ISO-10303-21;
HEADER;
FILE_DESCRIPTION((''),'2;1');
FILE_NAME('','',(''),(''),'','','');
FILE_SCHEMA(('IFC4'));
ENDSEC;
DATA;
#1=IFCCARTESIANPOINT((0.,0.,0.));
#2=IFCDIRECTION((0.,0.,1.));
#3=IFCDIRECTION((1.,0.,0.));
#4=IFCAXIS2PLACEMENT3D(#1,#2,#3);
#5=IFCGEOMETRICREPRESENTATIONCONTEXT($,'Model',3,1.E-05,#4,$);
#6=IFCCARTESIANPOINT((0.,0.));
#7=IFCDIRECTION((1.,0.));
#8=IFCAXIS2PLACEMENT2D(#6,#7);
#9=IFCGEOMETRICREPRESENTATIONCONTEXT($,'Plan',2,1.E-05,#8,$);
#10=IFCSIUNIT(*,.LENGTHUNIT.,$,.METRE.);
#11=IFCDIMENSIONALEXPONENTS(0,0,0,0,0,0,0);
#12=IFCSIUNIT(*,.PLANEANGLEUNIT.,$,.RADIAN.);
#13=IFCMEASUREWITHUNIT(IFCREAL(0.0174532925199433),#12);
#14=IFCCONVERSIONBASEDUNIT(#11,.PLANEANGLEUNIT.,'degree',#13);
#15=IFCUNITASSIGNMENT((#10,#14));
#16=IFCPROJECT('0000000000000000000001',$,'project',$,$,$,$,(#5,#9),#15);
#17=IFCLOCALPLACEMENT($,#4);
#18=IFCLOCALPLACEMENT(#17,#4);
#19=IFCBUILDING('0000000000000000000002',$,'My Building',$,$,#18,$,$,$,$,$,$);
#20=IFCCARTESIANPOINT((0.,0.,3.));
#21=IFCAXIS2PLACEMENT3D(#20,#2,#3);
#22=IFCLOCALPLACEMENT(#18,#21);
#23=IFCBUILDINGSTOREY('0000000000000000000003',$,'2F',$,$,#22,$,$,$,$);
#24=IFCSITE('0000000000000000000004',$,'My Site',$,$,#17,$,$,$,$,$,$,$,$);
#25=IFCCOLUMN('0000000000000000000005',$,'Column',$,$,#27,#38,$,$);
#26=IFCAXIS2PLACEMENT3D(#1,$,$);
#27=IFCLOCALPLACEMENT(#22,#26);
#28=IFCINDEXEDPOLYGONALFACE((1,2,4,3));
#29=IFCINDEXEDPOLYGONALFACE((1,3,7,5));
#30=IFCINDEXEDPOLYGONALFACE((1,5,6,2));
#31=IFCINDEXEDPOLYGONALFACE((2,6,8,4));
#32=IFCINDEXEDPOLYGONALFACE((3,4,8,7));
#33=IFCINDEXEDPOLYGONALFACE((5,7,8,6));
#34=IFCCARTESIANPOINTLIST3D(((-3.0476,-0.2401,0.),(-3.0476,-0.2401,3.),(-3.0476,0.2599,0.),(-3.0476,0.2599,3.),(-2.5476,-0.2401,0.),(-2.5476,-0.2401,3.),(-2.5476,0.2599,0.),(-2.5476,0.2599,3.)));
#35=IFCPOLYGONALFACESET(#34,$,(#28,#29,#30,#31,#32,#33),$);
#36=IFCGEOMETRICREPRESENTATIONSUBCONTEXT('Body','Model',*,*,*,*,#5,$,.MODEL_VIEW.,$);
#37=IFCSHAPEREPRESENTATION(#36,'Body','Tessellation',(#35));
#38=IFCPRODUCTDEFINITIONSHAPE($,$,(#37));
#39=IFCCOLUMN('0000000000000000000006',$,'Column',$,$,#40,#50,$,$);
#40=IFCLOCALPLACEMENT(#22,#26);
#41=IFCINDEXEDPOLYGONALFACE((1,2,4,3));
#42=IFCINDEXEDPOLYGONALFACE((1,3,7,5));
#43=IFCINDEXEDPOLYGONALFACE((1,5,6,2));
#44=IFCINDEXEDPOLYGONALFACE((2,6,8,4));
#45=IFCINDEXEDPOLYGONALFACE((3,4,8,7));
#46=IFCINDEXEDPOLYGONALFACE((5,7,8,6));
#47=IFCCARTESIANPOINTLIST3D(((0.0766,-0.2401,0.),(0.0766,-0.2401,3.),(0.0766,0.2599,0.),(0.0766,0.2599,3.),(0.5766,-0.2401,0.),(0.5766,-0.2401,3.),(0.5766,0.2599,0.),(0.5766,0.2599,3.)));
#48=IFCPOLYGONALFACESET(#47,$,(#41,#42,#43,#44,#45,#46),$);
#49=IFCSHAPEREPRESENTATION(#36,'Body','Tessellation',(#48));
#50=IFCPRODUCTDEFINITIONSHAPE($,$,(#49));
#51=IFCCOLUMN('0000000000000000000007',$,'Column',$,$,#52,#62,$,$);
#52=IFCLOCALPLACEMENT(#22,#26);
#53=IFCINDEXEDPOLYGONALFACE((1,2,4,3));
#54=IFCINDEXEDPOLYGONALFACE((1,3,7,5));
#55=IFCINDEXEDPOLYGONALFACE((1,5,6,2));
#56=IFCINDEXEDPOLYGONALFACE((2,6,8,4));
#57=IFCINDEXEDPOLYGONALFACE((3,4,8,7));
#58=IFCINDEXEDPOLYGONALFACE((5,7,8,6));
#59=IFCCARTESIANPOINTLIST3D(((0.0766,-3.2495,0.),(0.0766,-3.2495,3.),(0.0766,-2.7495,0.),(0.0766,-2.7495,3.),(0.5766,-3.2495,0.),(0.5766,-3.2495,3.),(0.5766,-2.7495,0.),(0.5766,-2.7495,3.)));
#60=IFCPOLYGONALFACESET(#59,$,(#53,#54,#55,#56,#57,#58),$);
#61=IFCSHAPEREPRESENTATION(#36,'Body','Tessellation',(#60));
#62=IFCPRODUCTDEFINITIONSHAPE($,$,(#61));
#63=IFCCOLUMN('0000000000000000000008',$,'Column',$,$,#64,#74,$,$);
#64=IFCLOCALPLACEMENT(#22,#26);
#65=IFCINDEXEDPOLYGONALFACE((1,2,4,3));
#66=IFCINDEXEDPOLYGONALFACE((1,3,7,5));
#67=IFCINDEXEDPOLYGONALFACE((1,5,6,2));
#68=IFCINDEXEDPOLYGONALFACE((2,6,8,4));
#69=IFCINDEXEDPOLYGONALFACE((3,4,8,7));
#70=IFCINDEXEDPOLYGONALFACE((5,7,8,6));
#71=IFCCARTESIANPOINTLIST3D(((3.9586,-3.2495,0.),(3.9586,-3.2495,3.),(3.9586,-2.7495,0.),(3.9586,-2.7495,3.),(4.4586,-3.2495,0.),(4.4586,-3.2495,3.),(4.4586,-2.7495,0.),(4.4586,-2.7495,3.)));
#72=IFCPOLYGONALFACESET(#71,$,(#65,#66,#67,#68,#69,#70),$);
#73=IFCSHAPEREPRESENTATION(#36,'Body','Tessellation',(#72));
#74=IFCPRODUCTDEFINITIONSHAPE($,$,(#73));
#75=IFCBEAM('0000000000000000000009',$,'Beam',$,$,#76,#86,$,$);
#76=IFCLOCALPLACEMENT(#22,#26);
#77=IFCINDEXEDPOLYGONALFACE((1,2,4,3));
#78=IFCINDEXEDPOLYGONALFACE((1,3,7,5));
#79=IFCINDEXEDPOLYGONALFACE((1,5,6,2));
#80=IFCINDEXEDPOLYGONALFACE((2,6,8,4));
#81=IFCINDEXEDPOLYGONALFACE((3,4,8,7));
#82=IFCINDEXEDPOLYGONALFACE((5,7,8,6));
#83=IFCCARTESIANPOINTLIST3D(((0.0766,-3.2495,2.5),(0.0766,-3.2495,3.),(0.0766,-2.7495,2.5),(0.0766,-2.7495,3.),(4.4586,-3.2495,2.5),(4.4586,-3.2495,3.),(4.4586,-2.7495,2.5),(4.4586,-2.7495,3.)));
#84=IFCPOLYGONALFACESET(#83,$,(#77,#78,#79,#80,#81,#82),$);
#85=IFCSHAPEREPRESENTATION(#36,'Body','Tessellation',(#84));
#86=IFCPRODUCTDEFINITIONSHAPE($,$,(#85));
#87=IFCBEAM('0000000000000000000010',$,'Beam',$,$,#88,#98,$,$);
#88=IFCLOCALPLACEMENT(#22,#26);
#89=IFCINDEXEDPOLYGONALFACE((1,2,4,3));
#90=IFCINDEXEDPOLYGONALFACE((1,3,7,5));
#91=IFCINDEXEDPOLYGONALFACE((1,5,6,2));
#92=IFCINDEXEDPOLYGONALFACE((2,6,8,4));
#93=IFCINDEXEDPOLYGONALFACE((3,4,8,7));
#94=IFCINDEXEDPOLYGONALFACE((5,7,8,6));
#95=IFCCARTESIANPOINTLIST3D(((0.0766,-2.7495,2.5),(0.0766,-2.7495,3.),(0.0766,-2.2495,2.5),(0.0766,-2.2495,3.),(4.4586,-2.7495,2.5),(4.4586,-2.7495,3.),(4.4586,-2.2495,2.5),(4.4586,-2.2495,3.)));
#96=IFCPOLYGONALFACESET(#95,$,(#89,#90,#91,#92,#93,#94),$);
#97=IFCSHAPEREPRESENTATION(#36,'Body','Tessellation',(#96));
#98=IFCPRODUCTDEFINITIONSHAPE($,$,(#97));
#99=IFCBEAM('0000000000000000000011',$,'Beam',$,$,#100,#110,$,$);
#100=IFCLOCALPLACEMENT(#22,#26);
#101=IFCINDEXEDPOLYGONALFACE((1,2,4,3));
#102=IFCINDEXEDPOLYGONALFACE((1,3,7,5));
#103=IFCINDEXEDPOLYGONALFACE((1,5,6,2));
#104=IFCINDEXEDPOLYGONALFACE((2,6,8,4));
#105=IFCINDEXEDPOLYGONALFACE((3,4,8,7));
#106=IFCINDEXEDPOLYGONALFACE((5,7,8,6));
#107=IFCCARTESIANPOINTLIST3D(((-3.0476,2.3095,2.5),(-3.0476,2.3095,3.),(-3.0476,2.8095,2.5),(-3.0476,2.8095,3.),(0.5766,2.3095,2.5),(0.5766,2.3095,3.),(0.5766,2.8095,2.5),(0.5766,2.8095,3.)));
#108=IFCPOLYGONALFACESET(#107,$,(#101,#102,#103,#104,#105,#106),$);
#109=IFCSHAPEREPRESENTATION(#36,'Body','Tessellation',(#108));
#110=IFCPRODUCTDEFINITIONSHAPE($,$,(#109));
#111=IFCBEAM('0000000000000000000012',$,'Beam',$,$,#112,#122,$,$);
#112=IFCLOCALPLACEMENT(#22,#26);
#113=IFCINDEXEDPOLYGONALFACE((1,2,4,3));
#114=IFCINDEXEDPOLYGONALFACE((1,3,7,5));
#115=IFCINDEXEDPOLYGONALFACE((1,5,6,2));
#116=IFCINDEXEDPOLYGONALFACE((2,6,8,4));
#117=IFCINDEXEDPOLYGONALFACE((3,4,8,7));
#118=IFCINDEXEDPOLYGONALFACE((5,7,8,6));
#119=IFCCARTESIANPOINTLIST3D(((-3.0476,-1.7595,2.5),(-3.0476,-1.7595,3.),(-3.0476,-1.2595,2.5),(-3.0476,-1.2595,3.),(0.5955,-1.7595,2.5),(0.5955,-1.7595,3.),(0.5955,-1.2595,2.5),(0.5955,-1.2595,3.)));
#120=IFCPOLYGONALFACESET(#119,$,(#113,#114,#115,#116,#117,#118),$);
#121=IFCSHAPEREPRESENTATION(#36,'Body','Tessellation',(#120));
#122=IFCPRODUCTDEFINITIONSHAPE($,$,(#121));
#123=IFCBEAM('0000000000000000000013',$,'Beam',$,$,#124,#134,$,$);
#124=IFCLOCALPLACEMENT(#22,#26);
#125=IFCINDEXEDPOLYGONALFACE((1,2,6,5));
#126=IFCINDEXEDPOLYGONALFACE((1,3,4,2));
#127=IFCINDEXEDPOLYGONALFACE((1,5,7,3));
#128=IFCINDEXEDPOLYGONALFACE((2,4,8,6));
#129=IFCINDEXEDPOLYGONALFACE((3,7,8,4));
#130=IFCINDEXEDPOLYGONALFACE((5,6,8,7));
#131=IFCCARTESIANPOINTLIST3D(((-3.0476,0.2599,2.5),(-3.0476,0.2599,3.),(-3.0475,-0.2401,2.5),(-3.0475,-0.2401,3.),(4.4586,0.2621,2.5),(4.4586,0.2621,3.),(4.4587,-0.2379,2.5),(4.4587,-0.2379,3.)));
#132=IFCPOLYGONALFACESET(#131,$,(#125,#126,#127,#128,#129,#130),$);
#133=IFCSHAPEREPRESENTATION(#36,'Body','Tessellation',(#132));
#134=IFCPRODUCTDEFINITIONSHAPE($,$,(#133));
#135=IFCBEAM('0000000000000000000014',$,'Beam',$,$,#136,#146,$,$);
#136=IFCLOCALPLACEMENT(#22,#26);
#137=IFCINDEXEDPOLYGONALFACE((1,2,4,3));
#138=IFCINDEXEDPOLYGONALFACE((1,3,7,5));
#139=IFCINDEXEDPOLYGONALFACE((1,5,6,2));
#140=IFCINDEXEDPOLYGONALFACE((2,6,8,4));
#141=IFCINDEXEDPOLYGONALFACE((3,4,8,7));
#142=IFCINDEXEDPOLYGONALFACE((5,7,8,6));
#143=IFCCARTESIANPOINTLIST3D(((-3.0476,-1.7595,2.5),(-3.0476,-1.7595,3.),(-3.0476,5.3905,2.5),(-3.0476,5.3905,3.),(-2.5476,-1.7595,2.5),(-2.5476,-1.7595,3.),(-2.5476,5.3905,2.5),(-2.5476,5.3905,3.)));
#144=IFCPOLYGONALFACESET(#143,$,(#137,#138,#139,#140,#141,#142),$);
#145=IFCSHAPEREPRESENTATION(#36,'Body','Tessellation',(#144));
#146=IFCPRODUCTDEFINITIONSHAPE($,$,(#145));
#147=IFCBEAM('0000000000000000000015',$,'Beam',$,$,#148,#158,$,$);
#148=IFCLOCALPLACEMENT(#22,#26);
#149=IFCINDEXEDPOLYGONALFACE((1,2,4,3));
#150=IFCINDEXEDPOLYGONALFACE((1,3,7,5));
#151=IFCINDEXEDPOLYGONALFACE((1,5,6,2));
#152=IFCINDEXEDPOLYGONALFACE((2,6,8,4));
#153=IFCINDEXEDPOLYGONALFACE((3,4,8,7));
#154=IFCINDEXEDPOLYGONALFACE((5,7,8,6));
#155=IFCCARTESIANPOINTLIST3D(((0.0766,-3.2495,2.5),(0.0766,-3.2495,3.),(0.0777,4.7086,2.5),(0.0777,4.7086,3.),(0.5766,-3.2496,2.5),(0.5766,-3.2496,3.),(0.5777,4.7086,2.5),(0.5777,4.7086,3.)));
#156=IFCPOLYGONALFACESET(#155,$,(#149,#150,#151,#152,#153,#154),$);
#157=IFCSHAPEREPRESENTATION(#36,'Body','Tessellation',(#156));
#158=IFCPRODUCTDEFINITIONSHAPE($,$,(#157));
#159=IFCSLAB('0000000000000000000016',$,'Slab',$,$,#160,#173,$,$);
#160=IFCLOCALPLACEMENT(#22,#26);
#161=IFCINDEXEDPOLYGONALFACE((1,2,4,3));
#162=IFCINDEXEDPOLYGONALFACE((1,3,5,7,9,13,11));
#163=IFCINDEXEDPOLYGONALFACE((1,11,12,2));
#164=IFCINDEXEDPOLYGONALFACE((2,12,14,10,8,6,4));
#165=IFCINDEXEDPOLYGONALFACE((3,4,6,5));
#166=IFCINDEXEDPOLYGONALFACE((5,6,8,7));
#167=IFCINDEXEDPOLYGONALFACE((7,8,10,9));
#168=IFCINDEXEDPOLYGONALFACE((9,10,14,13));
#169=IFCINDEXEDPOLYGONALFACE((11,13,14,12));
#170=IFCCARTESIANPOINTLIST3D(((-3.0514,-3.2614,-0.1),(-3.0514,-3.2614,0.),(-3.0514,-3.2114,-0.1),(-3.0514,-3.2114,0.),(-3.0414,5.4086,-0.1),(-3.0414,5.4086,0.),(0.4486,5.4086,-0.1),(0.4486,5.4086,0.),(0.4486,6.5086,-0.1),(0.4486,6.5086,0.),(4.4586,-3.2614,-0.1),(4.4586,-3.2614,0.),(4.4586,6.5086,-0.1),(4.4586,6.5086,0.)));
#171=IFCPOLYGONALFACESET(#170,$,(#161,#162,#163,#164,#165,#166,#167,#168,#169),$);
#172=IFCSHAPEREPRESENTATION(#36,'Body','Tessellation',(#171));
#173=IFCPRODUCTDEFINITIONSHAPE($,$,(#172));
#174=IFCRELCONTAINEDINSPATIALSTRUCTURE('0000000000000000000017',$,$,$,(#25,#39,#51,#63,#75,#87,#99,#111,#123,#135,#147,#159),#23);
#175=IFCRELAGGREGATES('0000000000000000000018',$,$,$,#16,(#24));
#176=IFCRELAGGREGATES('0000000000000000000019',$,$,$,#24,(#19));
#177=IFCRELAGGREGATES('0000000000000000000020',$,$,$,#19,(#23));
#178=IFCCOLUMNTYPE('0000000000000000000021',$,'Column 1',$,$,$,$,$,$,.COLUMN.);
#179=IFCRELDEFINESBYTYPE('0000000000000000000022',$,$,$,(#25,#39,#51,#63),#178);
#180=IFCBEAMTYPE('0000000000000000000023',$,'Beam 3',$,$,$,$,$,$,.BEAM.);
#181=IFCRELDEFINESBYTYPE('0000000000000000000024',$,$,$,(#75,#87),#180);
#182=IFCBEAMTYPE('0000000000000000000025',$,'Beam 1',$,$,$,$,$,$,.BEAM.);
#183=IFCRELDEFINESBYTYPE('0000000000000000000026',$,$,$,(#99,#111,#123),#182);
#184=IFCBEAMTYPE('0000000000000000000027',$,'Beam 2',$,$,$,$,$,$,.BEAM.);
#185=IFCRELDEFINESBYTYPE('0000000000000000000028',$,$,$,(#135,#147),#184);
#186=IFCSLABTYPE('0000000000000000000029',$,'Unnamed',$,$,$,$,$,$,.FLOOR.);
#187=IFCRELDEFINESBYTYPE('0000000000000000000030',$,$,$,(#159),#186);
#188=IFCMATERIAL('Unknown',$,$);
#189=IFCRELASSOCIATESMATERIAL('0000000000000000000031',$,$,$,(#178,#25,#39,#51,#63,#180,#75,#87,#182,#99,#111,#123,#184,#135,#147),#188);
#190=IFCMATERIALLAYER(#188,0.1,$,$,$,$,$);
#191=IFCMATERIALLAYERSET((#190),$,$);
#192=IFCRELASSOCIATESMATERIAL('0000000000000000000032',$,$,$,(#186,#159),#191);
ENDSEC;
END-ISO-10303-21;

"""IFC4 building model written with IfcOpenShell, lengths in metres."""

from ifc_helpers import new_model, entity, si_unit, converted_unit, frame, origin_with_axes, origin_2d_with_axis, place, context, subcontext, project, spatial, indexed_curve, outline, extrude, material, layer, layer_set, layer_usage, material_profile, profile_set, profile_usage, type_object, element, save


model = new_model("IFC4")

# Units and contexts
model_context = context("Model", 3, precision=1e-05, world=origin_with_axes())
plan_context = context("Plan", 2, precision=1e-05, world=origin_2d_with_axis())
body_context_1 = subcontext(model_context, "Body", "Model", "MODEL_VIEW")
ifc_project = project(units=[si_unit("LENGTHUNIT", "METRE"), converted_unit("PLANEANGLEUNIT", "degree", entity("IfcReal", 0.0174532925199433), si_unit("PLANEANGLEUNIT", "RADIAN"), dimensions=[0, 0, 0, 0, 0, 0, 0])], contexts=[model_context, plan_context])

# Site, building, storey
site_placement = place(None, origin_with_axes())
site = spatial("IfcSite", under=ifc_project, at=site_placement, Name="My Site")
building_placement = place(site_placement, origin_with_axes())
building = spatial("IfcBuilding", under=site, at=building_placement, Name="My Building")
storey_placement = place(building_placement, frame((0.0, 0.0, 3.0), z_axis=(0.0, 0.0, 1.0), x_axis=(1.0, 0.0, 0.0)))
storey = spatial("IfcBuildingStorey", under=building, at=storey_placement, Name="2F")

# Columns
ifc_material = material(Name="Unknown")
ifc_material_profile_1 = material_profile(ifc_material, outline(indexed_curve([(-0.25, -0.25), (0.25, -0.25), (0.25, 0.25), (-0.25, 0.25), (-0.25, -0.25)])))
ifc_profile_set_1 = profile_set([ifc_material_profile_1])
ifc_profile_usage_1 = profile_usage(ifc_profile_set_1, cardinal=7)
column_type = type_object("IfcColumnType", Name="Column 1", PredefinedType="COLUMN", material=ifc_profile_set_1)
column_1_placement = place(storey_placement, frame((-2.5476, 0.2599, 0.0), z_axis=(0.0, 0.0, 1.0), x_axis=(1.0, 0.0, 0.0)))
element("IfcColumn", 1, at=column_1_placement, inside=storey, type_object=column_type, material=ifc_profile_usage_1, Name="Column", context=body_context_1, shape_type="SweptSolid", body=[
    extrude(outline(indexed_curve([(-0.25, -0.25), (0.25, -0.25), (0.25, 0.25), (-0.25, 0.25), (-0.25, -0.25)])), frame((-0.25, -0.25, 0.0), z_axis=(0.0, 0.0, 1.0), x_axis=(1.0, 0.0, 0.0)), (0.0, 0.0, 1.0), 3.0),
])
ifc_profile_usage_2 = profile_usage(ifc_profile_set_1, cardinal=9)
column_2_placement = place(storey_placement, frame((0.0766, 0.2599, 0.0), z_axis=(0.0, 0.0, 1.0), x_axis=(1.0, 0.0, 0.0)))
element("IfcColumn", 2, at=column_2_placement, inside=storey, type_object=column_type, material=ifc_profile_usage_2, Name="Column", context=body_context_1, shape_type="SweptSolid", body=[
    extrude(outline(indexed_curve([(-0.25, -0.25), (0.25, -0.25), (0.25, 0.25), (-0.25, 0.25), (-0.25, -0.25)])), frame((0.25, -0.25, 0.0), z_axis=(0.0, 0.0, 1.0), x_axis=(1.0, 0.0, 0.0)), (0.0, 0.0, 1.0), 3.0),
])
ifc_profile_usage_3 = profile_usage(ifc_profile_set_1, cardinal=3)
column_3_placement = place(storey_placement, frame((0.0766, -3.2495, 0.0), z_axis=(0.0, 0.0, 1.0), x_axis=(1.0, 0.0, 0.0)))
element("IfcColumn", 3, at=column_3_placement, inside=storey, type_object=column_type, material=ifc_profile_usage_3, Name="Column", context=body_context_1, shape_type="SweptSolid", body=[
    extrude(outline(indexed_curve([(-0.25, -0.25), (0.25, -0.25), (0.25, 0.25), (-0.25, 0.25), (-0.25, -0.25)])), frame((0.25, 0.25, 0.0), z_axis=(0.0, 0.0, 1.0), x_axis=(1.0, 0.0, 0.0)), (0.0, 0.0, 1.0), 3.0),
])
ifc_profile_usage_4 = profile_usage(ifc_profile_set_1, cardinal=3)
column_4_placement = place(storey_placement, frame((3.9586, -3.2495, 0.0), z_axis=(0.0, 0.0, 1.0), x_axis=(1.0, 0.0, 0.0)))
element("IfcColumn", 4, at=column_4_placement, inside=storey, type_object=column_type, material=ifc_profile_usage_4, Name="Column", context=body_context_1, shape_type="SweptSolid", body=[
    extrude(outline(indexed_curve([(-0.25, -0.25), (0.25, -0.25), (0.25, 0.25), (-0.25, 0.25), (-0.25, -0.25)])), frame((0.25, 0.25, 0.0), z_axis=(0.0, 0.0, 1.0), x_axis=(1.0, 0.0, 0.0)), (0.0, 0.0, 1.0), 3.0),
])

# Beams
ifc_material_profile_2 = material_profile(ifc_material, outline(indexed_curve([(-0.25, -0.25), (0.25, -0.25), (0.25, 0.25), (-0.25, 0.25), (-0.25, -0.25)])))
ifc_profile_set_2 = profile_set([ifc_material_profile_2])
ifc_profile_usage_5 = profile_usage(ifc_profile_set_2, cardinal=7)
beam_type_1 = type_object("IfcBeamType", Name="Beam 3", PredefinedType="BEAM", material=ifc_profile_set_2)
beam_1_placement = place(storey_placement, frame((0.0766, -2.7495, 3.0), z_axis=(1.0, 0.0, 0.0), x_axis=(0.0, 1.0, 0.0)))
element("IfcBeam", 5, at=beam_1_placement, inside=storey, type_object=beam_type_1, material=ifc_profile_usage_5, Name="Beam", context=body_context_1, shape_type="SweptSolid", body=[
    extrude(outline(indexed_curve([(-0.25, -0.25), (0.25, -0.25), (0.25, 0.25), (-0.25, 0.25), (-0.25, -0.25)])), frame((-0.25, -0.25, 0.0), z_axis=(0.0, 0.0, 1.0), x_axis=(1.0, 0.0, 0.0)), (0.0, 0.0, 1.0), 4.382),
])
ifc_profile_usage_6 = profile_usage(ifc_profile_set_2, cardinal=7)
beam_2_placement = place(storey_placement, frame((0.0766, -2.2495, 3.0), z_axis=(1.0, 0.0, 0.0), x_axis=(0.0, 1.0, 0.0)))
element("IfcBeam", 6, at=beam_2_placement, inside=storey, type_object=beam_type_1, material=ifc_profile_usage_6, Name="Beam", context=body_context_1, shape_type="SweptSolid", body=[
    extrude(outline(indexed_curve([(-0.25, -0.25), (0.25, -0.25), (0.25, 0.25), (-0.25, 0.25), (-0.25, -0.25)])), frame((-0.25, -0.25, 0.0), z_axis=(0.0, 0.0, 1.0), x_axis=(1.0, 0.0, 0.0)), (0.0, 0.0, 1.0), 4.382),
])
ifc_material_profile_3 = material_profile(ifc_material, outline(indexed_curve([(-0.25, -0.25), (0.25, -0.25), (0.25, 0.25), (-0.25, 0.25), (-0.25, -0.25)])))
ifc_profile_set_3 = profile_set([ifc_material_profile_3])
ifc_profile_usage_7 = profile_usage(ifc_profile_set_3, cardinal=7)
beam_type_2 = type_object("IfcBeamType", Name="Beam 1", PredefinedType="BEAM", material=ifc_profile_set_3)
beam_3_placement = place(storey_placement, frame((0.5766, 2.3095, 3.0), z_axis=(-1.0, -0.000001, 0.000001), x_axis=(0.000001, -1.0, 0.0)))
element("IfcBeam", 7, at=beam_3_placement, inside=storey, type_object=beam_type_2, material=ifc_profile_usage_7, Name="Beam", context=body_context_1, shape_type="SweptSolid", body=[
    extrude(outline(indexed_curve([(-0.25, -0.25), (0.25, -0.25), (0.25, 0.25), (-0.25, 0.25), (-0.25, -0.25)])), frame((-0.25, -0.25, 0.0), z_axis=(0.0, 0.0, 1.0), x_axis=(1.0, 0.0, 0.0)), (0.0, 0.0, 1.0), 3.6242),
])
ifc_profile_usage_8 = profile_usage(ifc_profile_set_3, cardinal=1)
beam_4_placement = place(storey_placement, frame((-3.0476, -1.2595, 2.5), z_axis=(1.0, 0.0, 0.0), x_axis=(0.0, 1.0, 0.0)))
element("IfcBeam", 8, at=beam_4_placement, inside=storey, type_object=beam_type_2, material=ifc_profile_usage_8, Name="Beam", context=body_context_1, shape_type="SweptSolid", body=[
    extrude(outline(indexed_curve([(-0.25, -0.25), (0.25, -0.25), (0.25, 0.25), (-0.25, 0.25), (-0.25, -0.25)])), frame((-0.25, 0.25, 0.0), z_axis=(0.0, 0.0, 1.0), x_axis=(1.0, 0.0, 0.0)), (0.0, 0.0, 1.0), 3.6431),
])
ifc_profile_usage_9 = profile_usage(ifc_profile_set_3, cardinal=7)
beam_5_placement = place(storey_placement, frame((-3.0476, 0.2599, 3.0), z_axis=(1.0, 0.000292, 0.0), x_axis=(-0.000292, 1.0, 0.0)))
element("IfcBeam", 9, at=beam_5_placement, inside=storey, type_object=beam_type_2, material=ifc_profile_usage_9, Name="Beam", context=body_context_1, shape_type="SweptSolid", body=[
    extrude(outline(indexed_curve([(-0.25, -0.25), (0.25, -0.25), (0.25, 0.25), (-0.25, 0.25), (-0.25, -0.25)])), frame((-0.25, -0.25, 0.0), z_axis=(0.0, 0.0, 1.0), x_axis=(1.0, 0.0, 0.0)), (0.0, 0.0, 1.0), 7.5062),
])
ifc_material_profile_4 = material_profile(ifc_material, outline(indexed_curve([(-0.25, -0.25), (0.25, -0.25), (0.25, 0.25), (-0.25, 0.25), (-0.25, -0.25)])))
ifc_profile_set_4 = profile_set([ifc_material_profile_4])
ifc_profile_usage_10 = profile_usage(ifc_profile_set_4, cardinal=7)
beam_type_3 = type_object("IfcBeamType", Name="Beam 2", PredefinedType="BEAM", material=ifc_profile_set_4)
beam_6_placement = place(storey_placement, frame((-3.0476, -1.7595, 3.0), z_axis=(0.0, 1.0, 0.0), x_axis=(-1.0, 0.0, 0.0)))
element("IfcBeam", 10, at=beam_6_placement, inside=storey, type_object=beam_type_3, material=ifc_profile_usage_10, Name="Beam", context=body_context_1, shape_type="SweptSolid", body=[
    extrude(outline(indexed_curve([(-0.25, -0.25), (0.25, -0.25), (0.25, 0.25), (-0.25, 0.25), (-0.25, -0.25)])), frame((-0.25, -0.25, 0.0), z_axis=(0.0, 0.0, 1.0), x_axis=(1.0, 0.0, 0.0)), (0.0, 0.0, 1.0), 7.15),
])
ifc_profile_usage_11 = profile_usage(ifc_profile_set_4, cardinal=7)
beam_7_placement = place(storey_placement, frame((0.0766, -3.2495, 3.0), z_axis=(0.000142, 1.0, 0.0), x_axis=(-1.0, 0.000142, 0.0)))
element("IfcBeam", 11, at=beam_7_placement, inside=storey, type_object=beam_type_3, material=ifc_profile_usage_11, Name="Beam", context=body_context_1, shape_type="SweptSolid", body=[
    extrude(outline(indexed_curve([(-0.25, -0.25), (0.25, -0.25), (0.25, 0.25), (-0.25, 0.25), (-0.25, -0.25)])), frame((-0.25, -0.25, 0.0), z_axis=(0.0, 0.0, 1.0), x_axis=(1.0, 0.0, 0.0)), (0.0, 0.0, 1.0), 7.9582),
])

# Slab
ifc_layer_1 = layer(ifc_material, 0.1)
ifc_layer_set_1 = layer_set([ifc_layer_1])
ifc_layer_usage_1 = layer_usage(ifc_layer_set_1, "AXIS3", "POSITIVE", -0.1)
slab_type = type_object("IfcSlabType", Name="Unnamed", PredefinedType="FLOOR", material=ifc_layer_set_1)
slab_placement = place(storey_placement, frame((-3.0514, -3.2114, 0.0), z_axis=(0.0, 0.0, 1.0), x_axis=(1.0, 0.0, 0.0)))
element("IfcSlab", 12, at=slab_placement, inside=storey, type_object=slab_type, material=ifc_layer_usage_1, Name="Slab", context=body_context_1, shape_type="SweptSolid", body=[
    extrude(outline(indexed_curve([(0.0, 0.0), (0.0, -0.05), (7.51, -0.05), (7.51, 9.72), (3.5, 9.72), (3.5, 8.62), (0.01, 8.62), (0.0, 0.0)])), frame((0.0, 0.0, -0.1), z_axis=(0.0, 0.0, 1.0), x_axis=(1.0, 0.0, 0.0)), (0.0, 0.0, 1.0), 0.1),
])

save(model, "model.ifc")
